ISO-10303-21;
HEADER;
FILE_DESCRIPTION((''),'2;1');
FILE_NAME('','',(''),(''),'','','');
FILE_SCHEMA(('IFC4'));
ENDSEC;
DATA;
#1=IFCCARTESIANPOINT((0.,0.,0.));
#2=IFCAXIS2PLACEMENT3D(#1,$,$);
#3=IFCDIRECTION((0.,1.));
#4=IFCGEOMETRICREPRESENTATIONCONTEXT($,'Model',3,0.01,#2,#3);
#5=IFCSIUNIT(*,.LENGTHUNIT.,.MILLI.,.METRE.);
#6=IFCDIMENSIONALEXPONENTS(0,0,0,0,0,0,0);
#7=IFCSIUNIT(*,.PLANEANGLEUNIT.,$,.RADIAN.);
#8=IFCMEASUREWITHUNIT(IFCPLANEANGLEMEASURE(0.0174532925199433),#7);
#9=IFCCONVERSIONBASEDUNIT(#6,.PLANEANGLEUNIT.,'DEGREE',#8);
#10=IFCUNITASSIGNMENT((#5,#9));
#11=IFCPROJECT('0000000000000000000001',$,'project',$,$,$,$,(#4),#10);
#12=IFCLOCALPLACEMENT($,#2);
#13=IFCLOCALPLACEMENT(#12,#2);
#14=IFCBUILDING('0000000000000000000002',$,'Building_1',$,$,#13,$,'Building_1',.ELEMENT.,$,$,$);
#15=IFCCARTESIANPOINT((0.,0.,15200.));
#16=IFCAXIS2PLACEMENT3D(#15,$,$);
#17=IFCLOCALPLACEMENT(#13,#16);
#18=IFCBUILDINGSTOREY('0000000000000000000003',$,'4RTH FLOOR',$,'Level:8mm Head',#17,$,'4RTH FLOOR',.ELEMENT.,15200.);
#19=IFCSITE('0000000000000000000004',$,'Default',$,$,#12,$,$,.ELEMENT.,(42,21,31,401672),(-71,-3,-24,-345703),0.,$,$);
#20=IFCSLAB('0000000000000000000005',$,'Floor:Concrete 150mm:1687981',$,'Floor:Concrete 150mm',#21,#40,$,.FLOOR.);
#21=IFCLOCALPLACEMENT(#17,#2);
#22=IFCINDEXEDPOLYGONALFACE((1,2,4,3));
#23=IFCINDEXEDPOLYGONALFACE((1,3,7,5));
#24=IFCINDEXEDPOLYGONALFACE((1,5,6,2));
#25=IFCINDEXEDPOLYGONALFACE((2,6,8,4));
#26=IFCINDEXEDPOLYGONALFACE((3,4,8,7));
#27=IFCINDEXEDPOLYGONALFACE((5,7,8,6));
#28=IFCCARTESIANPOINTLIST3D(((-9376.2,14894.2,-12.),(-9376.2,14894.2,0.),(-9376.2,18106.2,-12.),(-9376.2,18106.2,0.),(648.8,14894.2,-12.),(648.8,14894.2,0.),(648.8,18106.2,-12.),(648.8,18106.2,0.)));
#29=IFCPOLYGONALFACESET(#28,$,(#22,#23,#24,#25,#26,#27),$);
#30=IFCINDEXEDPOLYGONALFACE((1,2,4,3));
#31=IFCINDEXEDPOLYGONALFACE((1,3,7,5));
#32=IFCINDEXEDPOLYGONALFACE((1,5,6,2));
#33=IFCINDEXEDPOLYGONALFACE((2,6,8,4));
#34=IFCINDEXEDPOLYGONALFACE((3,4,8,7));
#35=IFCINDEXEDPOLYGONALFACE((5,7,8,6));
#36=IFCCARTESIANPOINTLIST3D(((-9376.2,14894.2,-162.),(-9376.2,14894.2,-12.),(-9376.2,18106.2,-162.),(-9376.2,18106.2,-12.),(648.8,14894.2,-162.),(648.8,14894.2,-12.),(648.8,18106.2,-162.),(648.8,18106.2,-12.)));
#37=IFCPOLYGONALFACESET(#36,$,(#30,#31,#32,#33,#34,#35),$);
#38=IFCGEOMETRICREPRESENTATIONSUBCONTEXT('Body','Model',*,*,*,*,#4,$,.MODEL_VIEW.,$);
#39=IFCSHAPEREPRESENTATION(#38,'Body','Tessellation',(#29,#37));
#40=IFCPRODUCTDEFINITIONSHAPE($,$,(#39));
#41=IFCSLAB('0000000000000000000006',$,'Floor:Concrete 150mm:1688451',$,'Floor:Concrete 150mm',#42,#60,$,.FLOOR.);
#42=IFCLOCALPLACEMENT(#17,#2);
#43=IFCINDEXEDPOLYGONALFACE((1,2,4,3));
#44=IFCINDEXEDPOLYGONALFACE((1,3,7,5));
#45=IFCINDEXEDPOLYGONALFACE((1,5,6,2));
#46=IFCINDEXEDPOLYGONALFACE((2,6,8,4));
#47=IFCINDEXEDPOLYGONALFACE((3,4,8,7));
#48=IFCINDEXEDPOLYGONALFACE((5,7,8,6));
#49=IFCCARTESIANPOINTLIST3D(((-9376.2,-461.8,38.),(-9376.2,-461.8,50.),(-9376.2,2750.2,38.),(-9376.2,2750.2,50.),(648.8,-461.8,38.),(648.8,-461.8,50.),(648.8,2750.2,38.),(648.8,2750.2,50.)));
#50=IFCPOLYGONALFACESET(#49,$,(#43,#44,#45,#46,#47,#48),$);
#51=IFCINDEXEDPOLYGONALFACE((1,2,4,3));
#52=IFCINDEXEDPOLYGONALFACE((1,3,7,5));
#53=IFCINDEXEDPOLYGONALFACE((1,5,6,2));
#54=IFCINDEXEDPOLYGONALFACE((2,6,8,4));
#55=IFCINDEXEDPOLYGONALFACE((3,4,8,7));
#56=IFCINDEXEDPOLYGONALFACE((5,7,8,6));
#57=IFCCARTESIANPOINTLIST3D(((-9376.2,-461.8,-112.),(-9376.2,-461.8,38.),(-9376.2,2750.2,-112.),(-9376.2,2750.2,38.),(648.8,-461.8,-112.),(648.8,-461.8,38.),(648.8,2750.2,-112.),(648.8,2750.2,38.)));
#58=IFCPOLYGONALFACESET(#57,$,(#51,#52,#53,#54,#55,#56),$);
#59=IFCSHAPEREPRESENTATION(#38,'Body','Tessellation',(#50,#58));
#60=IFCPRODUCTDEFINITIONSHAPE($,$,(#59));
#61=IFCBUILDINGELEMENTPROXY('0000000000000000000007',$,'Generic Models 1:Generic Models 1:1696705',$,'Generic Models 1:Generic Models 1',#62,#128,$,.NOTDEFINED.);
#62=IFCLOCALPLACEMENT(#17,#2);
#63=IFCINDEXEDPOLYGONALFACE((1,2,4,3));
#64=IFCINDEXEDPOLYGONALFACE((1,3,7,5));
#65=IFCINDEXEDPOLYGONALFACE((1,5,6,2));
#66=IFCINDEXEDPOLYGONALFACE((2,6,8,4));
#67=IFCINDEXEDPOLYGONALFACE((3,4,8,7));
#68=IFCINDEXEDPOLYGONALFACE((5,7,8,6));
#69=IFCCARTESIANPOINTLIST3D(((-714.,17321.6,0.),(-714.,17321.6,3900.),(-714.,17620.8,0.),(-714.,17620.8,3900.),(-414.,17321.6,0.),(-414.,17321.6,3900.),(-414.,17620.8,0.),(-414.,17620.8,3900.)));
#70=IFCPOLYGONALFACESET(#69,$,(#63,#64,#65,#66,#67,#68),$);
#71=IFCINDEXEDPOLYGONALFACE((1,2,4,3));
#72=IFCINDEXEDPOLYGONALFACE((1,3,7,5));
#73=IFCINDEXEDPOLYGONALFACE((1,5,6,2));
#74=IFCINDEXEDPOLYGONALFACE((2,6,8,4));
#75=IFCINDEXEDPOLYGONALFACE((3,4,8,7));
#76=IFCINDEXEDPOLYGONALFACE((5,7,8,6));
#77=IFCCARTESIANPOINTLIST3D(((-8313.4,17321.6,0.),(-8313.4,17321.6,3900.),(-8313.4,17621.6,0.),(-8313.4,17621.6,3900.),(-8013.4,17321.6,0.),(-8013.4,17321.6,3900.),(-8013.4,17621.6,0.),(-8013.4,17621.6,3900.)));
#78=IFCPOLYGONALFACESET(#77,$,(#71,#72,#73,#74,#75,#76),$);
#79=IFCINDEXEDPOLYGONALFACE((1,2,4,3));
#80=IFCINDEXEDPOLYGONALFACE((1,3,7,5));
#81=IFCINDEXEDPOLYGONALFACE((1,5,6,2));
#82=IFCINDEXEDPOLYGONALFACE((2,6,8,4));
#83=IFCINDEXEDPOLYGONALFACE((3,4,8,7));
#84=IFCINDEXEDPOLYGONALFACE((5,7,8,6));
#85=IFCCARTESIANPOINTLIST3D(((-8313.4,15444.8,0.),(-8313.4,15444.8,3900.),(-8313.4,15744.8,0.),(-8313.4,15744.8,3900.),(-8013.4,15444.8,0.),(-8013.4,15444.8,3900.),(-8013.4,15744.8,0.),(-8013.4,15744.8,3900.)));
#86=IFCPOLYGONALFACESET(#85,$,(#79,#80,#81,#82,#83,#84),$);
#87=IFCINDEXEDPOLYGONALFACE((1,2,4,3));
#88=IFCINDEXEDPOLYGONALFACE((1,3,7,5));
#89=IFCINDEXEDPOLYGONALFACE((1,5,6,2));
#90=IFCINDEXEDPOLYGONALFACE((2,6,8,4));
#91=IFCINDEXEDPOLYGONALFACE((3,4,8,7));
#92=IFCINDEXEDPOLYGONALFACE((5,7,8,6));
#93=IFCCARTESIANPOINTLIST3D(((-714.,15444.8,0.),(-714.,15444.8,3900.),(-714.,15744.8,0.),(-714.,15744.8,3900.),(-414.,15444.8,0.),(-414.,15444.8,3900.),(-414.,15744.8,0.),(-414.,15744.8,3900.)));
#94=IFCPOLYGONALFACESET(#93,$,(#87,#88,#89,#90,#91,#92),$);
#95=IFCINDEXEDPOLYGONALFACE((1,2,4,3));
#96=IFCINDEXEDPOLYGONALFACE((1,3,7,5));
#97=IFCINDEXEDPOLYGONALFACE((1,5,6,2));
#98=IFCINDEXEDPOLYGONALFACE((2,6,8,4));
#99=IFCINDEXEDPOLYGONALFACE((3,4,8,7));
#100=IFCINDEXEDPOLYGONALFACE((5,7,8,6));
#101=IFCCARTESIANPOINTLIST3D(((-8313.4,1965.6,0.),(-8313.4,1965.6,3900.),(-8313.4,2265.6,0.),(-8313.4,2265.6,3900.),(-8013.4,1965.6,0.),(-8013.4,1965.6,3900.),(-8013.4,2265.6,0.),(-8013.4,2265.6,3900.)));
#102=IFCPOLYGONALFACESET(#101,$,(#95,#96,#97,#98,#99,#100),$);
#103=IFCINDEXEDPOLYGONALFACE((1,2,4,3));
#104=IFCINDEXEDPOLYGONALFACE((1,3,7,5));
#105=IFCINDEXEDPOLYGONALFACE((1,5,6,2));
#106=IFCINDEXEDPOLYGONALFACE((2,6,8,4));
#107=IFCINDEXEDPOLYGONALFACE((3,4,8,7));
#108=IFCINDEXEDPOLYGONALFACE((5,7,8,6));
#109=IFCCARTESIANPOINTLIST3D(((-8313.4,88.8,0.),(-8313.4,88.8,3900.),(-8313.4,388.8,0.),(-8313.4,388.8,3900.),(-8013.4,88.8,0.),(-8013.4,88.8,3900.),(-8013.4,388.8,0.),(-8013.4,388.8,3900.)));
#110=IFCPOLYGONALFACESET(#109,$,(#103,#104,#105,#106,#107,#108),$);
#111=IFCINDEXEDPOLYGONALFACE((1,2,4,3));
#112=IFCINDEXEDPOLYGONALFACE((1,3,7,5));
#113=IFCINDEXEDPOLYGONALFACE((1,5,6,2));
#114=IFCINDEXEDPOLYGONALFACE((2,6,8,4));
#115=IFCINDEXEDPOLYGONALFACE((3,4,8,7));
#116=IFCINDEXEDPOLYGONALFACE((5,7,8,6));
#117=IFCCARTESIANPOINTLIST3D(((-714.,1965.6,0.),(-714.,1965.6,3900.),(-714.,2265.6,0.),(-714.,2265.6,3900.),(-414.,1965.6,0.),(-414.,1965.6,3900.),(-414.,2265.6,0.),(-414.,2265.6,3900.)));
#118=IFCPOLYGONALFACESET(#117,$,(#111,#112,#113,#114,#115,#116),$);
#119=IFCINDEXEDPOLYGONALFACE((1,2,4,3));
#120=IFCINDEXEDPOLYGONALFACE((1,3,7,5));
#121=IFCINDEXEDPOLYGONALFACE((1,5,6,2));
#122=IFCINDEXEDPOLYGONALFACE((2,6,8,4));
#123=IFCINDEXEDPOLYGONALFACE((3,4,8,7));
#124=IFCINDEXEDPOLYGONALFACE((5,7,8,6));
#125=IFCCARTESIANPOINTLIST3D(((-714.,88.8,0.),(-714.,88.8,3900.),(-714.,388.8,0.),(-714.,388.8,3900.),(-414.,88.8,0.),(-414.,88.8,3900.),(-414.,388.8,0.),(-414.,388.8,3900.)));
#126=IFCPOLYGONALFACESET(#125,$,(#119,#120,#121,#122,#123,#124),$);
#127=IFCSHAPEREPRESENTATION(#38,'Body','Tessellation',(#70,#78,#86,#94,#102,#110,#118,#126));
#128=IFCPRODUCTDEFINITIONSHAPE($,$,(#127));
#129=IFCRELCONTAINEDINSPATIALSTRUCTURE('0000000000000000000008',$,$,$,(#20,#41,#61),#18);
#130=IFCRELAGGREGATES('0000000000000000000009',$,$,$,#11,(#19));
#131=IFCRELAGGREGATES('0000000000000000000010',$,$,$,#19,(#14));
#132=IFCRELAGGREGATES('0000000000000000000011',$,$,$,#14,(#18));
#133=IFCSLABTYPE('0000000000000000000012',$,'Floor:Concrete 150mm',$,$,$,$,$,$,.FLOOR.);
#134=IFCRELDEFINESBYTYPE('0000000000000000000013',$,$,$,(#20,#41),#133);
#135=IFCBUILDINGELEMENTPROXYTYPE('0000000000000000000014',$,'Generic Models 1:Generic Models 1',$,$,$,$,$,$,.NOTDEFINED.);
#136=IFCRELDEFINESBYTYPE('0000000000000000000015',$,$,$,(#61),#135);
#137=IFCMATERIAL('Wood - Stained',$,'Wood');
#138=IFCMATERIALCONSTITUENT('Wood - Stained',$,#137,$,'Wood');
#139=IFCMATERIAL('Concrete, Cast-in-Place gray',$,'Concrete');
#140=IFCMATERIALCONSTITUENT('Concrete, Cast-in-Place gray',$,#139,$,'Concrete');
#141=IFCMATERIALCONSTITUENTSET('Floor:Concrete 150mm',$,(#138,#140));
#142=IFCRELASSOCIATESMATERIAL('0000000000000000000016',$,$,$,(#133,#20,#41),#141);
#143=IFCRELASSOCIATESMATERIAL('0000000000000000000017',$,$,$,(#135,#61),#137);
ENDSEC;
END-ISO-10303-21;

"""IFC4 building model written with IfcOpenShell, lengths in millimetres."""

from ifc_helpers import new_model, entity, si_unit, converted_unit, direction, frame, origin, place, context, subcontext, project, spatial, indexed_curve, outline, extrude, source, transform, mapped, material, constituent, constituent_set, type_object, type_shapes, element, save


model = new_model("IFC4")

# Units and contexts
model_context = context("Model", 3, precision=0.01, world=origin(), true_north=direction((0.0, 1.0)))
body_context = subcontext(model_context, "Body", "Model", "MODEL_VIEW")
ifc_project = project(units=[si_unit("LENGTHUNIT", "METRE", prefix="MILLI"), converted_unit("PLANEANGLEUNIT", "DEGREE", entity("IfcPlaneAngleMeasure", 0.0174532925199433), si_unit("PLANEANGLEUNIT", "RADIAN"), dimensions=[0, 0, 0, 0, 0, 0, 0])], contexts=[model_context])

# Site, building, storey
site_placement = place(None, origin())
site = spatial("IfcSite", under=ifc_project, at=site_placement, Name="Default", CompositionType="ELEMENT", RefLatitude=(42, 21, 31, 401672), RefLongitude=(-71, -3, -24, -345703), RefElevation=0.0)
building_placement = place(site_placement, origin())
building = spatial("IfcBuilding", under=site, at=building_placement, Name="Building_1", LongName="Building_1", CompositionType="ELEMENT")
storey_placement = place(building_placement, frame((0.0, 0.0, 15200.0)))
storey = spatial("IfcBuildingStorey", under=building, at=storey_placement, Name="4RTH FLOOR", ObjectType="Level:8mm Head", LongName="4RTH FLOOR", CompositionType="ELEMENT", Elevation=15200.0)

# Slabs
ifc_material_1 = material(Name="Wood - Stained", Category="Wood")
ifc_constituent_1 = constituent(ifc_material_1, Name="Wood - Stained", Category="Wood")
ifc_material_2 = material(Name="Concrete, Cast-in-Place gray", Category="Concrete")
ifc_constituent_2 = constituent(ifc_material_2, Name="Concrete, Cast-in-Place gray", Category="Concrete")
ifc_constituent_set = constituent_set(constituents=[ifc_constituent_1, ifc_constituent_2], Name="Floor:Concrete 150mm")
slab_type = type_object("IfcSlabType", Name="Floor:Concrete 150mm", PredefinedType="FLOOR", material=ifc_constituent_set)
slab_1_placement = place(storey_placement, origin())
element("IfcSlab", 1, at=slab_1_placement, inside=storey, type_object=slab_type, material=ifc_constituent_set, Name="Floor:Concrete 150mm:1687981", ObjectType="Floor:Concrete 150mm", PredefinedType="FLOOR", context=body_context, shape_type="SweptSolid", body=[
    extrude(outline(indexed_curve([(-5012.5, -1606.0), (5012.5, -1606.0), (5012.5, 1606.0), (-5012.5, 1606.0), (-5012.5, -1606.0)], self_intersect=False)), frame((-4363.7, 16500.2, -12.0), z_axis=(0.0, 0.0, 1.0), x_axis=(-1.0, 0.0, 0.0)), (0.0, 0.0, 1.0), 12.0),
    extrude(outline(indexed_curve([(-5012.5, -1606.0), (5012.5, -1606.0), (5012.5, 1606.0), (-5012.5, 1606.0), (-5012.5, -1606.0)], self_intersect=False)), frame((-4363.7, 16500.2, -162.0), z_axis=(0.0, 0.0, 1.0), x_axis=(-1.0, 0.0, 0.0)), (0.0, 0.0, 1.0), 150.0),
])
slab_2_placement = place(storey_placement, origin())
element("IfcSlab", 2, at=slab_2_placement, inside=storey, type_object=slab_type, material=ifc_constituent_set, Name="Floor:Concrete 150mm:1688451", ObjectType="Floor:Concrete 150mm", PredefinedType="FLOOR", context=body_context, shape_type="SweptSolid", body=[
    extrude(outline(indexed_curve([(-5012.5, -1606.0), (5012.5, -1606.0), (5012.5, 1606.0), (-5012.5, 1606.0), (-5012.5, -1606.0)], self_intersect=False)), frame((-4363.7, 1144.2, 38.0), z_axis=(0.0, 0.0, 1.0), x_axis=(-1.0, 0.0, 0.0)), (0.0, 0.0, 1.0), 12.0),
    extrude(outline(indexed_curve([(-5012.5, -1606.0), (5012.5, -1606.0), (5012.5, 1606.0), (-5012.5, 1606.0), (-5012.5, -1606.0)], self_intersect=False)), frame((-4363.7, 1144.2, -112.0), z_axis=(0.0, 0.0, 1.0), x_axis=(-1.0, 0.0, 0.0)), (0.0, 0.0, 1.0), 150.0),
])

# Building element proxy
building_element_proxy_type_1 = type_object("IfcBuildingElementProxyType", Name="Generic Models 1:Generic Models 1", PredefinedType="NOTDEFINED", material=ifc_material_1)
shared_shape_1 = source(origin(), body_context, "Body", "SweptSolid", [
    extrude(outline(indexed_curve([(-149.6, -150.0), (149.6, -150.0), (149.6, 150.0), (-149.6, 150.0), (-149.6, -150.0)], self_intersect=False)), frame((-564.0, 17471.2, 15200.0), z_axis=(0.0, 0.0, 1.0), x_axis=(0.0, -1.0, 0.0)), (0.0, 0.0, 1.0), 3900.0),
    extrude(outline(indexed_curve([(-150.0, -150.0), (150.0, -150.0), (150.0, 150.0), (-150.0, 150.0), (-150.0, -150.0)], self_intersect=False)), frame((-8163.4, 17471.6, 15200.0), z_axis=(0.0, 0.0, 1.0), x_axis=(-1.0, 0.0, 0.0)), (0.0, 0.0, 1.0), 3900.0),
    extrude(outline(indexed_curve([(-150.0, -150.0), (150.0, -150.0), (150.0, 150.0), (-150.0, 150.0), (-150.0, -150.0)], self_intersect=False)), frame((-8163.4, 15594.8, 15200.0), z_axis=(0.0, 0.0, 1.0), x_axis=(-1.0, 0.0, 0.0)), (0.0, 0.0, 1.0), 3900.0),
    extrude(outline(indexed_curve([(-150.0, -150.0), (150.0, -150.0), (150.0, 150.0), (-150.0, 150.0), (-150.0, -150.0)], self_intersect=False)), frame((-564.0, 15594.8, 15200.0), z_axis=(0.0, 0.0, 1.0), x_axis=(0.0, -1.0, 0.0)), (0.0, 0.0, 1.0), 3900.0),
    extrude(outline(indexed_curve([(-150.0, -150.0), (150.0, -150.0), (150.0, 150.0), (-150.0, 150.0), (-150.0, -150.0)], self_intersect=False)), frame((-8163.4, 2115.6, 15200.0), z_axis=(0.0, 0.0, 1.0), x_axis=(-1.0, 0.0, 0.0)), (0.0, 0.0, 1.0), 3900.0),
    extrude(outline(indexed_curve([(-150.0, -150.0), (150.0, -150.0), (150.0, 150.0), (-150.0, 150.0), (-150.0, -150.0)], self_intersect=False)), frame((-8163.4, 238.8, 15200.0), z_axis=(0.0, 0.0, 1.0), x_axis=(-1.0, 0.0, 0.0)), (0.0, 0.0, 1.0), 3900.0),
    extrude(outline(indexed_curve([(-150.0, -150.0), (150.0, -150.0), (150.0, 150.0), (-150.0, 150.0), (-150.0, -150.0)], self_intersect=False)), frame((-564.0, 2115.6, 15200.0), z_axis=(0.0, 0.0, 1.0), x_axis=(0.0, -1.0, 0.0)), (0.0, 0.0, 1.0), 3900.0),
    extrude(outline(indexed_curve([(-150.0, -150.0), (150.0, -150.0), (150.0, 150.0), (-150.0, 150.0), (-150.0, -150.0)], self_intersect=False)), frame((-564.0, 238.8, 15200.0), z_axis=(0.0, 0.0, 1.0), x_axis=(0.0, -1.0, 0.0)), (0.0, 0.0, 1.0), 3900.0),
])
type_shapes(building_element_proxy_type_1, [shared_shape_1])
proxy_1_placement = place(storey_placement, frame((0.0, 0.0, -15200.0)))
element("IfcBuildingElementProxy", 3, at=proxy_1_placement, inside=storey, type_object=building_element_proxy_type_1, material=ifc_material_1, Name="Generic Models 1:Generic Models 1:1696705", ObjectType="Generic Models 1:Generic Models 1", PredefinedType="NOTDEFINED", context=body_context, shape_type="MappedRepresentation", body=[
    mapped(shared_shape_1, transform((0.0, 0.0, 0.0), scale=1.0)),
])

save(model, "model.ifc")
